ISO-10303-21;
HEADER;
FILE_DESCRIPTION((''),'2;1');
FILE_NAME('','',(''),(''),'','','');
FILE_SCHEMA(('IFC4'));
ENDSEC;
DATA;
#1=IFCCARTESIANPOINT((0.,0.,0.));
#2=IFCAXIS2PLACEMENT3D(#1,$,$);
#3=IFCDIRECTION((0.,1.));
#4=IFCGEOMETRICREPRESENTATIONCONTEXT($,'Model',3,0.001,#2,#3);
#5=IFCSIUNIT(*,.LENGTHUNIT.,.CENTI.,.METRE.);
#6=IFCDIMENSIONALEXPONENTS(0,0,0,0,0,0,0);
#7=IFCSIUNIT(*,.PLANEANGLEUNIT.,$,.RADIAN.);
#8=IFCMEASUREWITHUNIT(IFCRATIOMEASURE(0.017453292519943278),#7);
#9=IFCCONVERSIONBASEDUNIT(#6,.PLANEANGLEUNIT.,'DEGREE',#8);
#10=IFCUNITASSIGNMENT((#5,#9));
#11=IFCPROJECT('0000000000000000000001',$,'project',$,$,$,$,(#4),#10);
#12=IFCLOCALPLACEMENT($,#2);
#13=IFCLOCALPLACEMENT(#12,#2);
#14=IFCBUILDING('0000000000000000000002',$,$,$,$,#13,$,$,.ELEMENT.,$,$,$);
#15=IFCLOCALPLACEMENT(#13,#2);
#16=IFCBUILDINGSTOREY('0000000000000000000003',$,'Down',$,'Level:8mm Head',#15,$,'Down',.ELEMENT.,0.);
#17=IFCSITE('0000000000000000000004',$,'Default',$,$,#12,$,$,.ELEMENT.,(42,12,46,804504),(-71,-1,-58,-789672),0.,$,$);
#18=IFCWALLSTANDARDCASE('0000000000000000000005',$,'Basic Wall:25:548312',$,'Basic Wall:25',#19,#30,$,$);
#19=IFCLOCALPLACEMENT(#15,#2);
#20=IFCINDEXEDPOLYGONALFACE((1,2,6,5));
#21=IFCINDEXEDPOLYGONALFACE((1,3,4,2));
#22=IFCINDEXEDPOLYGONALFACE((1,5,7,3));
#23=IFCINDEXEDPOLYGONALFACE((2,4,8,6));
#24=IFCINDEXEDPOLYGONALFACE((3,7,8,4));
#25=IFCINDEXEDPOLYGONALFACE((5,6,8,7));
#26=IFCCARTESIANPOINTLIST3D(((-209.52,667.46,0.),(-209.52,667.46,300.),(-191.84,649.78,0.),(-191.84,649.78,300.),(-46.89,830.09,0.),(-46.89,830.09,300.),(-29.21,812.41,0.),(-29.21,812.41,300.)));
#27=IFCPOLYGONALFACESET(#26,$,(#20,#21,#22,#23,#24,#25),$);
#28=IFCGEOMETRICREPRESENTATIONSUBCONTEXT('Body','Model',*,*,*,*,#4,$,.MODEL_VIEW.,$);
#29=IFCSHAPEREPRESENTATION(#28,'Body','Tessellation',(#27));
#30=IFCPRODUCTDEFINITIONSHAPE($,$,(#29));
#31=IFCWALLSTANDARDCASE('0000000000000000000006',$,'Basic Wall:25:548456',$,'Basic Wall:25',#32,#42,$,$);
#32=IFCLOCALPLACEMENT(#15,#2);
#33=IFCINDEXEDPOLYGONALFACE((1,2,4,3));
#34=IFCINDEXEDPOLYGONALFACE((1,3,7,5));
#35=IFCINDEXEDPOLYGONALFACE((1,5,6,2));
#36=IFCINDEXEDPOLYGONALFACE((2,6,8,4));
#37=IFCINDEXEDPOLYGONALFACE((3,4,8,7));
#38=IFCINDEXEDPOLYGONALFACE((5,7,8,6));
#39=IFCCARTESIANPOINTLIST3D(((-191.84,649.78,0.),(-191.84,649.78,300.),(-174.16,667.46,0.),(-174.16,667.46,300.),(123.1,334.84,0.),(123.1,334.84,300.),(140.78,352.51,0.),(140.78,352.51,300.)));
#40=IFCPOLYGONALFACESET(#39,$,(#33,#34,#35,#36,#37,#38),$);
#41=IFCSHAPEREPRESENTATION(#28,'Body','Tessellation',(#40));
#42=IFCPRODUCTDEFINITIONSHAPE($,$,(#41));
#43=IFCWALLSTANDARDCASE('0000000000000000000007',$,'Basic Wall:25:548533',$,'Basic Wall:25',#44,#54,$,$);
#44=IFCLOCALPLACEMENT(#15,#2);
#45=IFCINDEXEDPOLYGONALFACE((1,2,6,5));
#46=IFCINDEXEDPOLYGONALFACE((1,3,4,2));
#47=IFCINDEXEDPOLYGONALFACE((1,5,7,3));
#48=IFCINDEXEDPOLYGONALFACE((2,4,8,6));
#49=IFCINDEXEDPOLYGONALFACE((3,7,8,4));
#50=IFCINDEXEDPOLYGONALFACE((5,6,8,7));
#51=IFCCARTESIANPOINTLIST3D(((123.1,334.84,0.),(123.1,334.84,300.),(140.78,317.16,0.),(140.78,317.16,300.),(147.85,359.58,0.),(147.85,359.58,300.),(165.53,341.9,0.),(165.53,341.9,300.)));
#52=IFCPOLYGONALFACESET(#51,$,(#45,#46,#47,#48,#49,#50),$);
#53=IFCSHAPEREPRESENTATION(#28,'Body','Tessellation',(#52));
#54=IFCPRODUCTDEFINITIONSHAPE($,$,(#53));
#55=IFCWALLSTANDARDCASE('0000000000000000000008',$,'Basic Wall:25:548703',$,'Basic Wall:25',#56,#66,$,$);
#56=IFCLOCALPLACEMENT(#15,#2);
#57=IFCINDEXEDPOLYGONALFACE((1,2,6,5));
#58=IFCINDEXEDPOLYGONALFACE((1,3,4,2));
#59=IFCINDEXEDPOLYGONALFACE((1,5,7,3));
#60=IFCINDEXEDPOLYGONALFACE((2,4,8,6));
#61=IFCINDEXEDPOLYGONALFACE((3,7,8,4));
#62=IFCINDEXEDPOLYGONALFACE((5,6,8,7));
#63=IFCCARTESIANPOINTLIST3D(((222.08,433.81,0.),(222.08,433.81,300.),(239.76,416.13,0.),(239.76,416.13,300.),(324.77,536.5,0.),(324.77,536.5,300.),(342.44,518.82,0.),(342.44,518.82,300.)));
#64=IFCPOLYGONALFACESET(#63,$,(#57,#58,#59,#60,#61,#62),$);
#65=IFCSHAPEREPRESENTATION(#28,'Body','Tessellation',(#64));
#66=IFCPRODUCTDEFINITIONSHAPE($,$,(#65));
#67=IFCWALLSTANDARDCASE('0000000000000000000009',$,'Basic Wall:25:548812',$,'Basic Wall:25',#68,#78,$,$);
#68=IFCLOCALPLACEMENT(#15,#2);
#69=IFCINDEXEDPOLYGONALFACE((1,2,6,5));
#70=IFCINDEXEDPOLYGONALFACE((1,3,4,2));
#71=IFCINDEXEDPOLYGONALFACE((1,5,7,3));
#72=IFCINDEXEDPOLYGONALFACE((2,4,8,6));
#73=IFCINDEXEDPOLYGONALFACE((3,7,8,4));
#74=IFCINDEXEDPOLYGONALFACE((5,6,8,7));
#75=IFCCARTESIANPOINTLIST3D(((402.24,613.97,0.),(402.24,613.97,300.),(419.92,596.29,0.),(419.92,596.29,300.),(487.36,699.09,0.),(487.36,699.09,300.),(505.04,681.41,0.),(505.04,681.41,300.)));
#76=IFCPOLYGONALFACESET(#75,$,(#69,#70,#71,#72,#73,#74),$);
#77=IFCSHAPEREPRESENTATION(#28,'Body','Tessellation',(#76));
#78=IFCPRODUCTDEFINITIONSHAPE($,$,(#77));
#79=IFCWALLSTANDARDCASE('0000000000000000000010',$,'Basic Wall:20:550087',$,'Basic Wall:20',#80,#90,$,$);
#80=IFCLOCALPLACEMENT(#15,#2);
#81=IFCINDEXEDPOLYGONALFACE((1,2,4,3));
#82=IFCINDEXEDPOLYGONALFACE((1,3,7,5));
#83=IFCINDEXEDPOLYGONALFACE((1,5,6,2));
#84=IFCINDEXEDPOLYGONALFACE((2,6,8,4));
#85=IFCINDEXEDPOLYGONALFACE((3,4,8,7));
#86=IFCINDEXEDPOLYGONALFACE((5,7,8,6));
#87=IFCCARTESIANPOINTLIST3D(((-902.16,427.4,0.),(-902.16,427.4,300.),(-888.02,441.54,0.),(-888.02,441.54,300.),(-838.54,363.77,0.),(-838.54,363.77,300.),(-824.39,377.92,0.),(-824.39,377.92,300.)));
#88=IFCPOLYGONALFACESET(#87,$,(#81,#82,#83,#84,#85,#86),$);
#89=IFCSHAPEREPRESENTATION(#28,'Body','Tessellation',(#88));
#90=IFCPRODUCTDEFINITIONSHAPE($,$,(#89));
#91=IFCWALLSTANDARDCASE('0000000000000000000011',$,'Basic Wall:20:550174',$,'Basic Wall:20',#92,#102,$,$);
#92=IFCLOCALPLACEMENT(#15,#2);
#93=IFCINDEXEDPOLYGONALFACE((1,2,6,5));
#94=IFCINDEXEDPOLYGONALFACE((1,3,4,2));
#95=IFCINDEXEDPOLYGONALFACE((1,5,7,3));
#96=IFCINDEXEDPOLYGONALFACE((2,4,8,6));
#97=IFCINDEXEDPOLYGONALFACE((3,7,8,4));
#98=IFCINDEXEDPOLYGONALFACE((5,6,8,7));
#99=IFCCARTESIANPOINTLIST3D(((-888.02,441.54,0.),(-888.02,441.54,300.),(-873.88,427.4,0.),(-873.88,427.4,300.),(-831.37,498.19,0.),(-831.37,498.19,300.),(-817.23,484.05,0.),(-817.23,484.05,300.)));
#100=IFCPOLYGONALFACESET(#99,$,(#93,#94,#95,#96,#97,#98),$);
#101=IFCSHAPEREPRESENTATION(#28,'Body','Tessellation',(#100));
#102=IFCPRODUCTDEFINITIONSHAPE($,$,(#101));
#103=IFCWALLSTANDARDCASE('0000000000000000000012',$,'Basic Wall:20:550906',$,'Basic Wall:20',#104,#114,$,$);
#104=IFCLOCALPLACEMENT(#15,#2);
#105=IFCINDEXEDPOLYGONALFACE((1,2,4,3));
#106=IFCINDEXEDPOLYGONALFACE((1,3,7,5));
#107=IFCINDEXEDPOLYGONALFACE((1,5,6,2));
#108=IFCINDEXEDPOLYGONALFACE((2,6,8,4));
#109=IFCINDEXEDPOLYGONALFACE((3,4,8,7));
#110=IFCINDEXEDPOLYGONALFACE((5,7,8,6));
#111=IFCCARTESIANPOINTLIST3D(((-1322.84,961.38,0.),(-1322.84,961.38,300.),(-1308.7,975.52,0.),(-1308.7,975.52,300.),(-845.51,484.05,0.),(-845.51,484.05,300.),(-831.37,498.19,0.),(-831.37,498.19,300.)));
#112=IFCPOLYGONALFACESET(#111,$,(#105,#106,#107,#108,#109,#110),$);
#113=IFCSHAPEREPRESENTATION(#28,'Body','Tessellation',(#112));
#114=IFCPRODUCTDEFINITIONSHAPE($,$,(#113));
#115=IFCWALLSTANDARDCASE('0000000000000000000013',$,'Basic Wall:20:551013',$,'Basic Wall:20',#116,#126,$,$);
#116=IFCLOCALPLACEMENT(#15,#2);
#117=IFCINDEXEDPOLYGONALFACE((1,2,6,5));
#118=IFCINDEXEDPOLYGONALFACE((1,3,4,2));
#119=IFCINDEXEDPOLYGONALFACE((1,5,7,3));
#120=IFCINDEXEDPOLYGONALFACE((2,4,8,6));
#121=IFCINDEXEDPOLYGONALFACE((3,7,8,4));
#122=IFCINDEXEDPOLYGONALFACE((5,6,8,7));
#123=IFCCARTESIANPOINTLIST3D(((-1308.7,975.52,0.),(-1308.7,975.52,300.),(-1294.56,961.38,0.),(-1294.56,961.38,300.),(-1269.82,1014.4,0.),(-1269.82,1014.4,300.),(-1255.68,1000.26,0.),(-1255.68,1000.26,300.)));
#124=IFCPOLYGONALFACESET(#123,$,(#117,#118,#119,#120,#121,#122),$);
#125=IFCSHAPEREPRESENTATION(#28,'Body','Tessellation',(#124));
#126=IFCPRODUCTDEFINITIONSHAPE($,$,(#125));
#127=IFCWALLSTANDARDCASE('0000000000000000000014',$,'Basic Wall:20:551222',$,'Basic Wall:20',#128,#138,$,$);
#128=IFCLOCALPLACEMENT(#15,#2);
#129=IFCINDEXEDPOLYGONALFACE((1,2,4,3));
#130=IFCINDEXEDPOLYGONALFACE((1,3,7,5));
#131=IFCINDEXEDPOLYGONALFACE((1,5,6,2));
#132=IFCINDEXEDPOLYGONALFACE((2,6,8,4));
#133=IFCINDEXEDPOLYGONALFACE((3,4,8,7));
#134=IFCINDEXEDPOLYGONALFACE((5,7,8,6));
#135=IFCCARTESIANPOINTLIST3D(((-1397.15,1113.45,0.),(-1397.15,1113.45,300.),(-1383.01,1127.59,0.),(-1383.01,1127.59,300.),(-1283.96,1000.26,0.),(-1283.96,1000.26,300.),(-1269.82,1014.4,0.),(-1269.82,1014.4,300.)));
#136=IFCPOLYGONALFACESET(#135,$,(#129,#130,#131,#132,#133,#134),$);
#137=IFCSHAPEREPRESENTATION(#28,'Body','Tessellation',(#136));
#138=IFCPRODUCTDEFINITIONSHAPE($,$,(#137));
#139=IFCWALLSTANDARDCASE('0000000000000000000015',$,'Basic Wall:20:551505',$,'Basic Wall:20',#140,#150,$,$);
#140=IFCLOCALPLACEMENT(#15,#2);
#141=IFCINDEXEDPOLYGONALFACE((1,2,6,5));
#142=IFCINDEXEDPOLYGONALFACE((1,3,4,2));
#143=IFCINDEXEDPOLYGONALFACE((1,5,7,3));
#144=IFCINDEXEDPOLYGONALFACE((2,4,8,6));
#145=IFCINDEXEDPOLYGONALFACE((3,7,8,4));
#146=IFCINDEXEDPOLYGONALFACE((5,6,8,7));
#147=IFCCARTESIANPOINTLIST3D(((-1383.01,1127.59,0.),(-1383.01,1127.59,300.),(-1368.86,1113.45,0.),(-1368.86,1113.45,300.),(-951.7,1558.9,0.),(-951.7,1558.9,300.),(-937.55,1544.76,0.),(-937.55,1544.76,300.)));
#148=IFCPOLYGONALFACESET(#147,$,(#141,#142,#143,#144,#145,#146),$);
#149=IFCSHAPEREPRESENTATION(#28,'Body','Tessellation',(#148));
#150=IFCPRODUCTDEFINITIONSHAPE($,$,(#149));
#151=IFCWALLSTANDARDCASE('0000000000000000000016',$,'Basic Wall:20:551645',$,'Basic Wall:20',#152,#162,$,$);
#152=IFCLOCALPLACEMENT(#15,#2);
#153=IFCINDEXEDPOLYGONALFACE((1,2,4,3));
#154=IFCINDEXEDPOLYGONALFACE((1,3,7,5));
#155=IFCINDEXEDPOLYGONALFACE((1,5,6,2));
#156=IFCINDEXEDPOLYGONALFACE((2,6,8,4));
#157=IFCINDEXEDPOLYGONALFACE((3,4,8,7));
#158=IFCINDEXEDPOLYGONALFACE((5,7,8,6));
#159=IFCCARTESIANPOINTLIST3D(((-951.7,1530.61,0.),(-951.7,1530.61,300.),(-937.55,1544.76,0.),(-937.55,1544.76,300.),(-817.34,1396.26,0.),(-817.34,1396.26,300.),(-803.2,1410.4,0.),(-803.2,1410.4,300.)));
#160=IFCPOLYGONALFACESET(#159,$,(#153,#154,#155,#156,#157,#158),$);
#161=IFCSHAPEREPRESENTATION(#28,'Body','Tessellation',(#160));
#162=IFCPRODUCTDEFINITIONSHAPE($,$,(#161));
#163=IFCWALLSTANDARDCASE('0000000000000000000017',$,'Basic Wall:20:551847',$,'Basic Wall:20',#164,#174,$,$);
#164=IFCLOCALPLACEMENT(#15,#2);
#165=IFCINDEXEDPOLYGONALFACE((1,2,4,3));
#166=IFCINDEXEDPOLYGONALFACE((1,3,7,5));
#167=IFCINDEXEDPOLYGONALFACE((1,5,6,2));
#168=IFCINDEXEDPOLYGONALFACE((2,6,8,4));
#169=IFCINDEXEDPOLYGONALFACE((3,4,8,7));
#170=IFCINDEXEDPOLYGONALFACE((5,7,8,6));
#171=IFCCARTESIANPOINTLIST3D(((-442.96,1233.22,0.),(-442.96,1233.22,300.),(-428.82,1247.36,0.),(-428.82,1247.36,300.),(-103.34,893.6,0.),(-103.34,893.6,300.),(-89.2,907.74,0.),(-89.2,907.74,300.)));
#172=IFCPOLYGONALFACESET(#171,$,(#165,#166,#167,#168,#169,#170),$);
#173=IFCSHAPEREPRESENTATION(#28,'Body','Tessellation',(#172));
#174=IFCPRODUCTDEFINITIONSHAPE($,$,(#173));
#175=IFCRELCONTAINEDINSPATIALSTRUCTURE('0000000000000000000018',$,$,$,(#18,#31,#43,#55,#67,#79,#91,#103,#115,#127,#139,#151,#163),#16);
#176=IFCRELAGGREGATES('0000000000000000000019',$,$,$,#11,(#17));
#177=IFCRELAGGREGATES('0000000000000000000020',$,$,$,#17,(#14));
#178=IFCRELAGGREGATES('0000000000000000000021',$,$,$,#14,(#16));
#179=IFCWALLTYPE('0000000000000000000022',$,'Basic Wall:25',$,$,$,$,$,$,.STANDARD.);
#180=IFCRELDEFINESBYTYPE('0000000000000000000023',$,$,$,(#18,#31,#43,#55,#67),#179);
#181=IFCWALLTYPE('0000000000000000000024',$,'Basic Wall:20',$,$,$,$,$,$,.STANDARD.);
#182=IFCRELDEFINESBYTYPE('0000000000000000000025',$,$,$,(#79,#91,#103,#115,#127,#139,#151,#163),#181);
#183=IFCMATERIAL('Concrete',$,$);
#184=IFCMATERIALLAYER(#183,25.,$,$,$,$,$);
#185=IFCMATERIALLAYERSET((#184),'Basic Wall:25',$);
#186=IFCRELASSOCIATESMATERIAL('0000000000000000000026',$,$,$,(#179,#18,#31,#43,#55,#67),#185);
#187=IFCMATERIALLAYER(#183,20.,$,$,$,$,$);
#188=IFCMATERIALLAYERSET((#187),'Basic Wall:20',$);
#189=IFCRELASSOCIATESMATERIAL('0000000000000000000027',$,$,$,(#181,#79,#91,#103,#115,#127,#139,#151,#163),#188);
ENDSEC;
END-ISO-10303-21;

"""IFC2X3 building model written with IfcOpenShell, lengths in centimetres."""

from ifc_helpers import new_model, entity, si_unit, converted_unit, direction, frame, frame_2d, origin, place, context, subcontext, project, spatial, rectangle, extrude, material, layer, layer_set, layer_usage, type_object, element, save


model = new_model("IFC2X3")

# Units and contexts
model_context = context("Model", 3, precision=0.001, world=origin(), true_north=direction((0.0, 1.0)))
body_context = subcontext(model_context, "Body", "Model", "MODEL_VIEW")
ifc_project = project(units=[si_unit("LENGTHUNIT", "METRE", prefix="CENTI"), converted_unit("PLANEANGLEUNIT", "DEGREE", entity("IfcRatioMeasure", 0.017453292519943278), si_unit("PLANEANGLEUNIT", "RADIAN"), dimensions=[0, 0, 0, 0, 0, 0, 0])], contexts=[model_context])

# Site, building, storey
site_placement = place(None, origin())
site = spatial("IfcSite", under=ifc_project, at=site_placement, Name="Default", CompositionType="ELEMENT", RefLatitude=(42, 12, 46, 804504), RefLongitude=(-71, -1, -58, -789672), RefElevation=0.0)
building_placement = place(site_placement, origin())
building = spatial("IfcBuilding", under=site, at=building_placement, CompositionType="ELEMENT")
storey_placement = place(building_placement, origin())
storey = spatial("IfcBuildingStorey", under=building, at=storey_placement, Name="Down", ObjectType="Level:8mm Head", LongName="Down", CompositionType="ELEMENT", Elevation=0.0)

# Walls
ifc_material = material(Name="Concrete")
ifc_layer_1 = layer(ifc_material, 25.0)
ifc_layer_set_1 = layer_set([ifc_layer_1], Name="Basic Wall:25")
wall_type_1 = type_object("IfcWallType", Name="Basic Wall:25", PredefinedType="STANDARD", material=ifc_layer_set_1)
ifc_layer_usage_1 = layer_usage(ifc_layer_set_1, "AXIS2", "NEGATIVE", 12.5)
wall_1_placement = place(storey_placement, frame((-38.05, 821.25, 0.0), z_axis=(0.0, 0.0, 1.0), x_axis=(-0.707107, -0.707107, 0.0)))
element("IfcWallStandardCase", 1, at=wall_1_placement, inside=storey, type_object=wall_type_1, material=ifc_layer_usage_1, Name="Basic Wall:25:548312", ObjectType="Basic Wall:25", context=body_context, shape_type="SweptSolid", body=[
    extrude(rectangle(XDim=229.99, YDim=25.0, at=frame_2d((115.0, 0.0), x_axis=(-1.0, 0.0))), origin(), (0.0, 0.0, 1.0), 300.0),
])
ifc_layer_usage_2 = layer_usage(ifc_layer_set_1, "AXIS2", "POSITIVE", -12.5)
wall_2_placement = place(storey_placement, frame((-183.0, 658.62, 0.0), z_axis=(0.0, 0.0, 1.0), x_axis=(0.707107, -0.707107, 0.0)))
element("IfcWallStandardCase", 2, at=wall_2_placement, inside=storey, type_object=wall_type_1, material=ifc_layer_usage_2, Name="Basic Wall:25:548456", ObjectType="Basic Wall:25", context=body_context, shape_type="SweptSolid", body=[
    extrude(rectangle(XDim=445.4, YDim=25.0, at=frame_2d((222.7, 0.0), x_axis=(-1.0, 0.0))), origin(), (0.0, 0.0, 1.0), 300.0),
])
ifc_layer_usage_3 = layer_usage(ifc_layer_set_1, "AXIS2", "POSITIVE", -12.5)
wall_3_placement = place(storey_placement, frame((131.94, 326.0, 0.0), z_axis=(0.0, 0.0, 1.0), x_axis=(0.707107, 0.707107, 0.0)))
element("IfcWallStandardCase", 3, at=wall_3_placement, inside=storey, type_object=wall_type_1, material=ifc_layer_usage_3, Name="Basic Wall:25:548533", ObjectType="Basic Wall:25", context=body_context, shape_type="SweptSolid", body=[
    extrude(rectangle(XDim=34.99, YDim=25.0, at=frame_2d((17.5, 0.0), x_axis=(-1.0, 0.0))), origin(), (0.0, 0.0, 1.0), 300.0),
])
ifc_layer_usage_4 = layer_usage(ifc_layer_set_1, "AXIS2", "POSITIVE", -12.5)
wall_4_placement = place(storey_placement, frame((230.92, 424.97, 0.0), z_axis=(0.0, 0.0, 1.0), x_axis=(0.707107, 0.707107, 0.0)))
element("IfcWallStandardCase", 4, at=wall_4_placement, inside=storey, type_object=wall_type_1, material=ifc_layer_usage_4, Name="Basic Wall:25:548703", ObjectType="Basic Wall:25", context=body_context, shape_type="SweptSolid", body=[
    extrude(rectangle(XDim=145.22, YDim=25.0, at=frame_2d((72.61, 0.0), x_axis=(-1.0, 0.0))), origin(), (0.0, 0.0, 1.0), 300.0),
])
ifc_layer_usage_5 = layer_usage(ifc_layer_set_1, "AXIS2", "POSITIVE", -12.5)
wall_5_placement = place(storey_placement, frame((411.08, 605.13, 0.0), z_axis=(0.0, 0.0, 1.0), x_axis=(0.707107, 0.707107, 0.0)))
element("IfcWallStandardCase", 5, at=wall_5_placement, inside=storey, type_object=wall_type_1, material=ifc_layer_usage_5, Name="Basic Wall:25:548812", ObjectType="Basic Wall:25", context=body_context, shape_type="SweptSolid", body=[
    extrude(rectangle(XDim=120.37, YDim=25.0, at=frame_2d((60.19, 0.0), x_axis=(-1.0, 0.0))), origin(), (0.0, 0.0, 1.0), 300.0),
])
ifc_layer_2 = layer(ifc_material, 20.0)
ifc_layer_set_2 = layer_set([ifc_layer_2], Name="Basic Wall:20")
ifc_layer_usage_6 = layer_usage(ifc_layer_set_2, "AXIS2", "NEGATIVE", 10.0)
wall_type_2 = type_object("IfcWallType", Name="Basic Wall:20", PredefinedType="STANDARD", material=ifc_layer_set_2)
wall_6_placement = place(storey_placement, frame((-831.46, 370.84, 0.0), z_axis=(0.0, 0.0, 1.0), x_axis=(-0.707107, 0.707107, 0.0)))
element("IfcWallStandardCase", 6, at=wall_6_placement, inside=storey, type_object=wall_type_2, material=ifc_layer_usage_6, Name="Basic Wall:20:550087", ObjectType="Basic Wall:20", context=body_context, shape_type="SweptSolid", body=[
    extrude(rectangle(XDim=89.98, YDim=20.0, at=frame_2d((44.99, 0.0), x_axis=(-1.0, 0.0))), origin(), (0.0, 0.0, 1.0), 300.0),
])
ifc_layer_usage_7 = layer_usage(ifc_layer_set_2, "AXIS2", "NEGATIVE", 10.0)
wall_7_placement = place(storey_placement, frame((-880.95, 434.47, 0.0), z_axis=(0.0, 0.0, 1.0), x_axis=(0.707107, 0.707107, 0.0)))
element("IfcWallStandardCase", 7, at=wall_7_placement, inside=storey, type_object=wall_type_2, material=ifc_layer_usage_7, Name="Basic Wall:20:550174", ObjectType="Basic Wall:20", context=body_context, shape_type="SweptSolid", body=[
    extrude(rectangle(XDim=80.12, YDim=20.0, at=frame_2d((40.06, 0.0), x_axis=(-1.0, 0.0))), origin(), (0.0, 0.0, 1.0), 300.0),
])
ifc_layer_usage_8 = layer_usage(ifc_layer_set_2, "AXIS2", "NEGATIVE", 10.0)
wall_8_placement = place(storey_placement, frame((-838.44, 491.12, 0.0), z_axis=(0.0, 0.0, 1.0), x_axis=(-0.707107, 0.707107, 0.0)))
element("IfcWallStandardCase", 8, at=wall_8_placement, inside=storey, type_object=wall_type_2, material=ifc_layer_usage_8, Name="Basic Wall:20:550906", ObjectType="Basic Wall:20", context=body_context, shape_type="SweptSolid", body=[
    extrude(rectangle(XDim=675.05, YDim=20.0, at=frame_2d((337.52, 0.0), x_axis=(-1.0, 0.0))), origin(), (0.0, 0.0, 1.0), 300.0),
])
ifc_layer_usage_9 = layer_usage(ifc_layer_set_2, "AXIS2", "NEGATIVE", 10.0)
wall_9_placement = place(storey_placement, frame((-1301.63, 968.45, 0.0), z_axis=(0.0, 0.0, 1.0), x_axis=(0.707107, 0.707107, 0.0)))
element("IfcWallStandardCase", 9, at=wall_9_placement, inside=storey, type_object=wall_type_2, material=ifc_layer_usage_9, Name="Basic Wall:20:551013", ObjectType="Basic Wall:20", context=body_context, shape_type="SweptSolid", body=[
    extrude(rectangle(XDim=54.98, YDim=20.0, at=frame_2d((27.49, 0.0), x_axis=(-1.0, 0.0))), origin(), (0.0, 0.0, 1.0), 300.0),
])
ifc_layer_usage_10 = layer_usage(ifc_layer_set_2, "AXIS2", "POSITIVE", -10.0)
wall_10_placement = place(storey_placement, frame((-1276.89, 1007.33, 0.0), z_axis=(0.0, 0.0, 1.0), x_axis=(-0.707107, 0.707107, 0.0)))
element("IfcWallStandardCase", 10, at=wall_10_placement, inside=storey, type_object=wall_type_2, material=ifc_layer_usage_10, Name="Basic Wall:20:551222", ObjectType="Basic Wall:20", context=body_context, shape_type="SweptSolid", body=[
    extrude(rectangle(XDim=160.07, YDim=20.0, at=frame_2d((80.03, 0.0), x_axis=(-1.0, 0.0))), origin(), (0.0, 0.0, 1.0), 300.0),
])
ifc_layer_usage_11 = layer_usage(ifc_layer_set_2, "AXIS2", "POSITIVE", -10.0)
wall_11_placement = place(storey_placement, frame((-1375.94, 1120.52, 0.0), z_axis=(0.0, 0.0, 1.0), x_axis=(0.707107, 0.707107, 0.0)))
element("IfcWallStandardCase", 11, at=wall_11_placement, inside=storey, type_object=wall_type_2, material=ifc_layer_usage_11, Name="Basic Wall:20:551505", ObjectType="Basic Wall:20", context=body_context, shape_type="SweptSolid", body=[
    extrude(rectangle(XDim=609.97, YDim=20.0, at=frame_2d((304.98, 0.0), x_axis=(-1.0, 0.0))), origin(), (0.0, 0.0, 1.0), 300.0),
])
ifc_layer_usage_12 = layer_usage(ifc_layer_set_2, "AXIS2", "POSITIVE", -10.0)
wall_12_placement = place(storey_placement, frame((-944.62, 1537.68, 0.0), z_axis=(0.0, 0.0, 1.0), x_axis=(0.707107, -0.707107, 0.0)))
element("IfcWallStandardCase", 12, at=wall_12_placement, inside=storey, type_object=wall_type_2, material=ifc_layer_usage_12, Name="Basic Wall:20:551645", ObjectType="Basic Wall:20", context=body_context, shape_type="SweptSolid", body=[
    extrude(rectangle(XDim=190.01, YDim=20.0, at=frame_2d((95.0, 0.0), x_axis=(-1.0, 0.0))), origin(), (0.0, 0.0, 1.0), 300.0),
])
ifc_layer_usage_13 = layer_usage(ifc_layer_set_2, "AXIS2", "NEGATIVE", 10.0)
wall_13_placement = place(storey_placement, frame((-435.89, 1240.29, 0.0), z_axis=(0.0, 0.0, 1.0), x_axis=(0.707107, -0.707107, 0.0)))
element("IfcWallStandardCase", 13, at=wall_13_placement, inside=storey, type_object=wall_type_2, material=ifc_layer_usage_13, Name="Basic Wall:20:551847", ObjectType="Basic Wall:20", context=body_context, shape_type="SweptSolid", body=[
    extrude(rectangle(XDim=480.29, YDim=20.0, at=frame_2d((240.15, 0.0), x_axis=(-1.0, 0.0))), origin(), (0.0, 0.0, 1.0), 300.0),
])

save(model, "model.ifc")
